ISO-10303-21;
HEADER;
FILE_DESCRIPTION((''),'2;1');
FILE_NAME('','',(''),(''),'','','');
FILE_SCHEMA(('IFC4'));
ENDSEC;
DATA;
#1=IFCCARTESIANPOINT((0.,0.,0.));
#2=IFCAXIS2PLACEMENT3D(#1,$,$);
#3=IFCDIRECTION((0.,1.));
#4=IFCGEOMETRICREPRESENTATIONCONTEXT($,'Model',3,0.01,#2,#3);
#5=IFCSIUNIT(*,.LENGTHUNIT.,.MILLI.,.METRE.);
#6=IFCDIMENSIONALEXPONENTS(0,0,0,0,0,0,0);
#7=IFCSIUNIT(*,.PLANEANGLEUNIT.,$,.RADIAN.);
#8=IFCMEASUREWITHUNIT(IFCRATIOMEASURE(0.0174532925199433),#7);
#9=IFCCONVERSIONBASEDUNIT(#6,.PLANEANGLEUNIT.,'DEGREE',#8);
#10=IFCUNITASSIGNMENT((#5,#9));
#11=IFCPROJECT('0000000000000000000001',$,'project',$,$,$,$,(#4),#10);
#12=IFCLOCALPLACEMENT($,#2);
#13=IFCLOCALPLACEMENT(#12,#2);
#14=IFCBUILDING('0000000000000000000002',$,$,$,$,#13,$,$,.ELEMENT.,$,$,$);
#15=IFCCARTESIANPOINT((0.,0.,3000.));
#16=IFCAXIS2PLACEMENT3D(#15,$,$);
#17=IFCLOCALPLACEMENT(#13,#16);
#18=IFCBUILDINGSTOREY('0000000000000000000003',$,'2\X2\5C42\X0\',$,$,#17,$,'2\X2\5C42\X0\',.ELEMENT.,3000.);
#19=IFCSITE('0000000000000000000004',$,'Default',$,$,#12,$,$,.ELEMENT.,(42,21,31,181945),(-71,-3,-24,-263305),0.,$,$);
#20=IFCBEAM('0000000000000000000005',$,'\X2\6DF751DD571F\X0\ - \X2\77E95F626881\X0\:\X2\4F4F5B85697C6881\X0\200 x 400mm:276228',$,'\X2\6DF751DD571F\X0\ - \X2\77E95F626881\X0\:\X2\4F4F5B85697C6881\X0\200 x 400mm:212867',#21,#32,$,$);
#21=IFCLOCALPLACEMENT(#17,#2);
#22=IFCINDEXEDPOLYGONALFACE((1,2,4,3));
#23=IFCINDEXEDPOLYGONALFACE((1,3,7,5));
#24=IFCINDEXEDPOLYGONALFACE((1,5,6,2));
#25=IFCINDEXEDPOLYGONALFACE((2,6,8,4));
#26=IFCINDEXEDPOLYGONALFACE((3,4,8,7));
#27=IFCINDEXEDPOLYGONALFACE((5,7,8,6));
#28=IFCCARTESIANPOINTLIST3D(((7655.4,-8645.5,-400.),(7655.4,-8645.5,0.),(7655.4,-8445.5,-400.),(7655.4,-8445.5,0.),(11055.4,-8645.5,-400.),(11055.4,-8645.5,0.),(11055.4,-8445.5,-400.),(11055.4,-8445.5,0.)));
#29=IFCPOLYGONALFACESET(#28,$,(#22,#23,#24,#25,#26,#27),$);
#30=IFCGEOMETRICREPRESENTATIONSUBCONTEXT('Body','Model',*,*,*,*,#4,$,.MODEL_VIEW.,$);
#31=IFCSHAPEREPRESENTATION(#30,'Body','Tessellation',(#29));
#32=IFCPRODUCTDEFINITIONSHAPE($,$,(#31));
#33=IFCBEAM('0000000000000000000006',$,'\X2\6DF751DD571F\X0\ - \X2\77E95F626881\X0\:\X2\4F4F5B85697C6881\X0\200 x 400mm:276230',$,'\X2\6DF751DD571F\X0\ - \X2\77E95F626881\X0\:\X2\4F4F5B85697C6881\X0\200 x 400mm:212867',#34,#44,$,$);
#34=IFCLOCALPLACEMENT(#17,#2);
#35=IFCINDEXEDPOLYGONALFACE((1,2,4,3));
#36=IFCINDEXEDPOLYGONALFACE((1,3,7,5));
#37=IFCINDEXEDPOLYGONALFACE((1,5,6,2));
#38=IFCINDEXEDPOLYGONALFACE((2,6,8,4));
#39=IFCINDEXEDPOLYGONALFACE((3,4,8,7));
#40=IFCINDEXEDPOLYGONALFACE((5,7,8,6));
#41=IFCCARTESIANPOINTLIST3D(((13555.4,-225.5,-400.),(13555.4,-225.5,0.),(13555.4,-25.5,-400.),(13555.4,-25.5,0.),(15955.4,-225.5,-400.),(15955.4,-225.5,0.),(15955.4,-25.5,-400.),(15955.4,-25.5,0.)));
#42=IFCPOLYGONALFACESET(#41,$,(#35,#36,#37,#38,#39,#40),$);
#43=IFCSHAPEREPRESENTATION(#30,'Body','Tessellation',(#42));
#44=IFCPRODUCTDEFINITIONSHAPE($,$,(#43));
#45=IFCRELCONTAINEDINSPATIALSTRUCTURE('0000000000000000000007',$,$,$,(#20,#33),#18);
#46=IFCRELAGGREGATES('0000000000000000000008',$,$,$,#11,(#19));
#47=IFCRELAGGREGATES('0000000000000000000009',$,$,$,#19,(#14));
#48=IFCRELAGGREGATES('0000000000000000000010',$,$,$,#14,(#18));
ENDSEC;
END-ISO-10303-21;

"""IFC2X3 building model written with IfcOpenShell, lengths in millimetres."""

from ifc_helpers import new_model, entity, si_unit, converted_unit, direction, frame, frame_2d, origin, place, context, subcontext, project, spatial, rectangle, extrude, element, save


model = new_model("IFC2X3")

# Units and contexts
model_context = context("Model", 3, precision=0.01, world=origin(), true_north=direction((0.0, 1.0)))
body_context = subcontext(model_context, "Body", "Model", "MODEL_VIEW")
ifc_project = project(units=[si_unit("LENGTHUNIT", "METRE", prefix="MILLI"), converted_unit("PLANEANGLEUNIT", "DEGREE", entity("IfcRatioMeasure", 0.0174532925199433), si_unit("PLANEANGLEUNIT", "RADIAN"), dimensions=[0, 0, 0, 0, 0, 0, 0])], contexts=[model_context])

# Site, building, storey
site_placement = place(None, origin())
site = spatial("IfcSite", under=ifc_project, at=site_placement, Name="Default", CompositionType="ELEMENT", RefLatitude=(42, 21, 31, 181945), RefLongitude=(-71, -3, -24, -263305), RefElevation=0.0)
building_placement = place(site_placement, origin())
building = spatial("IfcBuilding", under=site, at=building_placement, CompositionType="ELEMENT")
storey_placement = place(building_placement, frame((0.0, 0.0, 3000.0)))
storey = spatial("IfcBuildingStorey", under=building, at=storey_placement, Name="2层", LongName="2层", CompositionType="ELEMENT", Elevation=3000.0)

# Beams
beam_1_placement = place(storey_placement, frame((7555.4, -8545.5, 0.0)))
element("IfcBeam", 1, at=beam_1_placement, inside=storey, Name="混凝土 - 矩形梁:住宅楼梁200 x 400mm:276228", ObjectType="混凝土 - 矩形梁:住宅楼梁200 x 400mm:212867", context=body_context, shape_type="SweptSolid", body=[
    extrude(rectangle(XDim=400.0, YDim=200.0, at=frame_2d((0.0, 0.0), x_axis=(1.0, 0.0))), frame((100.0, 0.0, -200.0), z_axis=(1.0, 0.0, 0.0), x_axis=(0.0, 0.0, -1.0)), (0.0, 0.0, 1.0), 3400.0),
])
beam_2_placement = place(storey_placement, frame((16055.4, -125.5, 0.0), z_axis=(0.0, 0.0, 1.0), x_axis=(-1.0, 0.0, 0.0)))
element("IfcBeam", 2, at=beam_2_placement, inside=storey, Name="混凝土 - 矩形梁:住宅楼梁200 x 400mm:276230", ObjectType="混凝土 - 矩形梁:住宅楼梁200 x 400mm:212867", context=body_context, shape_type="SweptSolid", body=[
    extrude(rectangle(XDim=400.0, YDim=200.0, at=frame_2d((0.0, 0.0), x_axis=(1.0, 0.0))), frame((100.0, 0.0, -200.0), z_axis=(1.0, 0.0, 0.0), x_axis=(0.0, 0.0, -1.0)), (0.0, 0.0, 1.0), 2400.0),
])

save(model, "model.ifc")
